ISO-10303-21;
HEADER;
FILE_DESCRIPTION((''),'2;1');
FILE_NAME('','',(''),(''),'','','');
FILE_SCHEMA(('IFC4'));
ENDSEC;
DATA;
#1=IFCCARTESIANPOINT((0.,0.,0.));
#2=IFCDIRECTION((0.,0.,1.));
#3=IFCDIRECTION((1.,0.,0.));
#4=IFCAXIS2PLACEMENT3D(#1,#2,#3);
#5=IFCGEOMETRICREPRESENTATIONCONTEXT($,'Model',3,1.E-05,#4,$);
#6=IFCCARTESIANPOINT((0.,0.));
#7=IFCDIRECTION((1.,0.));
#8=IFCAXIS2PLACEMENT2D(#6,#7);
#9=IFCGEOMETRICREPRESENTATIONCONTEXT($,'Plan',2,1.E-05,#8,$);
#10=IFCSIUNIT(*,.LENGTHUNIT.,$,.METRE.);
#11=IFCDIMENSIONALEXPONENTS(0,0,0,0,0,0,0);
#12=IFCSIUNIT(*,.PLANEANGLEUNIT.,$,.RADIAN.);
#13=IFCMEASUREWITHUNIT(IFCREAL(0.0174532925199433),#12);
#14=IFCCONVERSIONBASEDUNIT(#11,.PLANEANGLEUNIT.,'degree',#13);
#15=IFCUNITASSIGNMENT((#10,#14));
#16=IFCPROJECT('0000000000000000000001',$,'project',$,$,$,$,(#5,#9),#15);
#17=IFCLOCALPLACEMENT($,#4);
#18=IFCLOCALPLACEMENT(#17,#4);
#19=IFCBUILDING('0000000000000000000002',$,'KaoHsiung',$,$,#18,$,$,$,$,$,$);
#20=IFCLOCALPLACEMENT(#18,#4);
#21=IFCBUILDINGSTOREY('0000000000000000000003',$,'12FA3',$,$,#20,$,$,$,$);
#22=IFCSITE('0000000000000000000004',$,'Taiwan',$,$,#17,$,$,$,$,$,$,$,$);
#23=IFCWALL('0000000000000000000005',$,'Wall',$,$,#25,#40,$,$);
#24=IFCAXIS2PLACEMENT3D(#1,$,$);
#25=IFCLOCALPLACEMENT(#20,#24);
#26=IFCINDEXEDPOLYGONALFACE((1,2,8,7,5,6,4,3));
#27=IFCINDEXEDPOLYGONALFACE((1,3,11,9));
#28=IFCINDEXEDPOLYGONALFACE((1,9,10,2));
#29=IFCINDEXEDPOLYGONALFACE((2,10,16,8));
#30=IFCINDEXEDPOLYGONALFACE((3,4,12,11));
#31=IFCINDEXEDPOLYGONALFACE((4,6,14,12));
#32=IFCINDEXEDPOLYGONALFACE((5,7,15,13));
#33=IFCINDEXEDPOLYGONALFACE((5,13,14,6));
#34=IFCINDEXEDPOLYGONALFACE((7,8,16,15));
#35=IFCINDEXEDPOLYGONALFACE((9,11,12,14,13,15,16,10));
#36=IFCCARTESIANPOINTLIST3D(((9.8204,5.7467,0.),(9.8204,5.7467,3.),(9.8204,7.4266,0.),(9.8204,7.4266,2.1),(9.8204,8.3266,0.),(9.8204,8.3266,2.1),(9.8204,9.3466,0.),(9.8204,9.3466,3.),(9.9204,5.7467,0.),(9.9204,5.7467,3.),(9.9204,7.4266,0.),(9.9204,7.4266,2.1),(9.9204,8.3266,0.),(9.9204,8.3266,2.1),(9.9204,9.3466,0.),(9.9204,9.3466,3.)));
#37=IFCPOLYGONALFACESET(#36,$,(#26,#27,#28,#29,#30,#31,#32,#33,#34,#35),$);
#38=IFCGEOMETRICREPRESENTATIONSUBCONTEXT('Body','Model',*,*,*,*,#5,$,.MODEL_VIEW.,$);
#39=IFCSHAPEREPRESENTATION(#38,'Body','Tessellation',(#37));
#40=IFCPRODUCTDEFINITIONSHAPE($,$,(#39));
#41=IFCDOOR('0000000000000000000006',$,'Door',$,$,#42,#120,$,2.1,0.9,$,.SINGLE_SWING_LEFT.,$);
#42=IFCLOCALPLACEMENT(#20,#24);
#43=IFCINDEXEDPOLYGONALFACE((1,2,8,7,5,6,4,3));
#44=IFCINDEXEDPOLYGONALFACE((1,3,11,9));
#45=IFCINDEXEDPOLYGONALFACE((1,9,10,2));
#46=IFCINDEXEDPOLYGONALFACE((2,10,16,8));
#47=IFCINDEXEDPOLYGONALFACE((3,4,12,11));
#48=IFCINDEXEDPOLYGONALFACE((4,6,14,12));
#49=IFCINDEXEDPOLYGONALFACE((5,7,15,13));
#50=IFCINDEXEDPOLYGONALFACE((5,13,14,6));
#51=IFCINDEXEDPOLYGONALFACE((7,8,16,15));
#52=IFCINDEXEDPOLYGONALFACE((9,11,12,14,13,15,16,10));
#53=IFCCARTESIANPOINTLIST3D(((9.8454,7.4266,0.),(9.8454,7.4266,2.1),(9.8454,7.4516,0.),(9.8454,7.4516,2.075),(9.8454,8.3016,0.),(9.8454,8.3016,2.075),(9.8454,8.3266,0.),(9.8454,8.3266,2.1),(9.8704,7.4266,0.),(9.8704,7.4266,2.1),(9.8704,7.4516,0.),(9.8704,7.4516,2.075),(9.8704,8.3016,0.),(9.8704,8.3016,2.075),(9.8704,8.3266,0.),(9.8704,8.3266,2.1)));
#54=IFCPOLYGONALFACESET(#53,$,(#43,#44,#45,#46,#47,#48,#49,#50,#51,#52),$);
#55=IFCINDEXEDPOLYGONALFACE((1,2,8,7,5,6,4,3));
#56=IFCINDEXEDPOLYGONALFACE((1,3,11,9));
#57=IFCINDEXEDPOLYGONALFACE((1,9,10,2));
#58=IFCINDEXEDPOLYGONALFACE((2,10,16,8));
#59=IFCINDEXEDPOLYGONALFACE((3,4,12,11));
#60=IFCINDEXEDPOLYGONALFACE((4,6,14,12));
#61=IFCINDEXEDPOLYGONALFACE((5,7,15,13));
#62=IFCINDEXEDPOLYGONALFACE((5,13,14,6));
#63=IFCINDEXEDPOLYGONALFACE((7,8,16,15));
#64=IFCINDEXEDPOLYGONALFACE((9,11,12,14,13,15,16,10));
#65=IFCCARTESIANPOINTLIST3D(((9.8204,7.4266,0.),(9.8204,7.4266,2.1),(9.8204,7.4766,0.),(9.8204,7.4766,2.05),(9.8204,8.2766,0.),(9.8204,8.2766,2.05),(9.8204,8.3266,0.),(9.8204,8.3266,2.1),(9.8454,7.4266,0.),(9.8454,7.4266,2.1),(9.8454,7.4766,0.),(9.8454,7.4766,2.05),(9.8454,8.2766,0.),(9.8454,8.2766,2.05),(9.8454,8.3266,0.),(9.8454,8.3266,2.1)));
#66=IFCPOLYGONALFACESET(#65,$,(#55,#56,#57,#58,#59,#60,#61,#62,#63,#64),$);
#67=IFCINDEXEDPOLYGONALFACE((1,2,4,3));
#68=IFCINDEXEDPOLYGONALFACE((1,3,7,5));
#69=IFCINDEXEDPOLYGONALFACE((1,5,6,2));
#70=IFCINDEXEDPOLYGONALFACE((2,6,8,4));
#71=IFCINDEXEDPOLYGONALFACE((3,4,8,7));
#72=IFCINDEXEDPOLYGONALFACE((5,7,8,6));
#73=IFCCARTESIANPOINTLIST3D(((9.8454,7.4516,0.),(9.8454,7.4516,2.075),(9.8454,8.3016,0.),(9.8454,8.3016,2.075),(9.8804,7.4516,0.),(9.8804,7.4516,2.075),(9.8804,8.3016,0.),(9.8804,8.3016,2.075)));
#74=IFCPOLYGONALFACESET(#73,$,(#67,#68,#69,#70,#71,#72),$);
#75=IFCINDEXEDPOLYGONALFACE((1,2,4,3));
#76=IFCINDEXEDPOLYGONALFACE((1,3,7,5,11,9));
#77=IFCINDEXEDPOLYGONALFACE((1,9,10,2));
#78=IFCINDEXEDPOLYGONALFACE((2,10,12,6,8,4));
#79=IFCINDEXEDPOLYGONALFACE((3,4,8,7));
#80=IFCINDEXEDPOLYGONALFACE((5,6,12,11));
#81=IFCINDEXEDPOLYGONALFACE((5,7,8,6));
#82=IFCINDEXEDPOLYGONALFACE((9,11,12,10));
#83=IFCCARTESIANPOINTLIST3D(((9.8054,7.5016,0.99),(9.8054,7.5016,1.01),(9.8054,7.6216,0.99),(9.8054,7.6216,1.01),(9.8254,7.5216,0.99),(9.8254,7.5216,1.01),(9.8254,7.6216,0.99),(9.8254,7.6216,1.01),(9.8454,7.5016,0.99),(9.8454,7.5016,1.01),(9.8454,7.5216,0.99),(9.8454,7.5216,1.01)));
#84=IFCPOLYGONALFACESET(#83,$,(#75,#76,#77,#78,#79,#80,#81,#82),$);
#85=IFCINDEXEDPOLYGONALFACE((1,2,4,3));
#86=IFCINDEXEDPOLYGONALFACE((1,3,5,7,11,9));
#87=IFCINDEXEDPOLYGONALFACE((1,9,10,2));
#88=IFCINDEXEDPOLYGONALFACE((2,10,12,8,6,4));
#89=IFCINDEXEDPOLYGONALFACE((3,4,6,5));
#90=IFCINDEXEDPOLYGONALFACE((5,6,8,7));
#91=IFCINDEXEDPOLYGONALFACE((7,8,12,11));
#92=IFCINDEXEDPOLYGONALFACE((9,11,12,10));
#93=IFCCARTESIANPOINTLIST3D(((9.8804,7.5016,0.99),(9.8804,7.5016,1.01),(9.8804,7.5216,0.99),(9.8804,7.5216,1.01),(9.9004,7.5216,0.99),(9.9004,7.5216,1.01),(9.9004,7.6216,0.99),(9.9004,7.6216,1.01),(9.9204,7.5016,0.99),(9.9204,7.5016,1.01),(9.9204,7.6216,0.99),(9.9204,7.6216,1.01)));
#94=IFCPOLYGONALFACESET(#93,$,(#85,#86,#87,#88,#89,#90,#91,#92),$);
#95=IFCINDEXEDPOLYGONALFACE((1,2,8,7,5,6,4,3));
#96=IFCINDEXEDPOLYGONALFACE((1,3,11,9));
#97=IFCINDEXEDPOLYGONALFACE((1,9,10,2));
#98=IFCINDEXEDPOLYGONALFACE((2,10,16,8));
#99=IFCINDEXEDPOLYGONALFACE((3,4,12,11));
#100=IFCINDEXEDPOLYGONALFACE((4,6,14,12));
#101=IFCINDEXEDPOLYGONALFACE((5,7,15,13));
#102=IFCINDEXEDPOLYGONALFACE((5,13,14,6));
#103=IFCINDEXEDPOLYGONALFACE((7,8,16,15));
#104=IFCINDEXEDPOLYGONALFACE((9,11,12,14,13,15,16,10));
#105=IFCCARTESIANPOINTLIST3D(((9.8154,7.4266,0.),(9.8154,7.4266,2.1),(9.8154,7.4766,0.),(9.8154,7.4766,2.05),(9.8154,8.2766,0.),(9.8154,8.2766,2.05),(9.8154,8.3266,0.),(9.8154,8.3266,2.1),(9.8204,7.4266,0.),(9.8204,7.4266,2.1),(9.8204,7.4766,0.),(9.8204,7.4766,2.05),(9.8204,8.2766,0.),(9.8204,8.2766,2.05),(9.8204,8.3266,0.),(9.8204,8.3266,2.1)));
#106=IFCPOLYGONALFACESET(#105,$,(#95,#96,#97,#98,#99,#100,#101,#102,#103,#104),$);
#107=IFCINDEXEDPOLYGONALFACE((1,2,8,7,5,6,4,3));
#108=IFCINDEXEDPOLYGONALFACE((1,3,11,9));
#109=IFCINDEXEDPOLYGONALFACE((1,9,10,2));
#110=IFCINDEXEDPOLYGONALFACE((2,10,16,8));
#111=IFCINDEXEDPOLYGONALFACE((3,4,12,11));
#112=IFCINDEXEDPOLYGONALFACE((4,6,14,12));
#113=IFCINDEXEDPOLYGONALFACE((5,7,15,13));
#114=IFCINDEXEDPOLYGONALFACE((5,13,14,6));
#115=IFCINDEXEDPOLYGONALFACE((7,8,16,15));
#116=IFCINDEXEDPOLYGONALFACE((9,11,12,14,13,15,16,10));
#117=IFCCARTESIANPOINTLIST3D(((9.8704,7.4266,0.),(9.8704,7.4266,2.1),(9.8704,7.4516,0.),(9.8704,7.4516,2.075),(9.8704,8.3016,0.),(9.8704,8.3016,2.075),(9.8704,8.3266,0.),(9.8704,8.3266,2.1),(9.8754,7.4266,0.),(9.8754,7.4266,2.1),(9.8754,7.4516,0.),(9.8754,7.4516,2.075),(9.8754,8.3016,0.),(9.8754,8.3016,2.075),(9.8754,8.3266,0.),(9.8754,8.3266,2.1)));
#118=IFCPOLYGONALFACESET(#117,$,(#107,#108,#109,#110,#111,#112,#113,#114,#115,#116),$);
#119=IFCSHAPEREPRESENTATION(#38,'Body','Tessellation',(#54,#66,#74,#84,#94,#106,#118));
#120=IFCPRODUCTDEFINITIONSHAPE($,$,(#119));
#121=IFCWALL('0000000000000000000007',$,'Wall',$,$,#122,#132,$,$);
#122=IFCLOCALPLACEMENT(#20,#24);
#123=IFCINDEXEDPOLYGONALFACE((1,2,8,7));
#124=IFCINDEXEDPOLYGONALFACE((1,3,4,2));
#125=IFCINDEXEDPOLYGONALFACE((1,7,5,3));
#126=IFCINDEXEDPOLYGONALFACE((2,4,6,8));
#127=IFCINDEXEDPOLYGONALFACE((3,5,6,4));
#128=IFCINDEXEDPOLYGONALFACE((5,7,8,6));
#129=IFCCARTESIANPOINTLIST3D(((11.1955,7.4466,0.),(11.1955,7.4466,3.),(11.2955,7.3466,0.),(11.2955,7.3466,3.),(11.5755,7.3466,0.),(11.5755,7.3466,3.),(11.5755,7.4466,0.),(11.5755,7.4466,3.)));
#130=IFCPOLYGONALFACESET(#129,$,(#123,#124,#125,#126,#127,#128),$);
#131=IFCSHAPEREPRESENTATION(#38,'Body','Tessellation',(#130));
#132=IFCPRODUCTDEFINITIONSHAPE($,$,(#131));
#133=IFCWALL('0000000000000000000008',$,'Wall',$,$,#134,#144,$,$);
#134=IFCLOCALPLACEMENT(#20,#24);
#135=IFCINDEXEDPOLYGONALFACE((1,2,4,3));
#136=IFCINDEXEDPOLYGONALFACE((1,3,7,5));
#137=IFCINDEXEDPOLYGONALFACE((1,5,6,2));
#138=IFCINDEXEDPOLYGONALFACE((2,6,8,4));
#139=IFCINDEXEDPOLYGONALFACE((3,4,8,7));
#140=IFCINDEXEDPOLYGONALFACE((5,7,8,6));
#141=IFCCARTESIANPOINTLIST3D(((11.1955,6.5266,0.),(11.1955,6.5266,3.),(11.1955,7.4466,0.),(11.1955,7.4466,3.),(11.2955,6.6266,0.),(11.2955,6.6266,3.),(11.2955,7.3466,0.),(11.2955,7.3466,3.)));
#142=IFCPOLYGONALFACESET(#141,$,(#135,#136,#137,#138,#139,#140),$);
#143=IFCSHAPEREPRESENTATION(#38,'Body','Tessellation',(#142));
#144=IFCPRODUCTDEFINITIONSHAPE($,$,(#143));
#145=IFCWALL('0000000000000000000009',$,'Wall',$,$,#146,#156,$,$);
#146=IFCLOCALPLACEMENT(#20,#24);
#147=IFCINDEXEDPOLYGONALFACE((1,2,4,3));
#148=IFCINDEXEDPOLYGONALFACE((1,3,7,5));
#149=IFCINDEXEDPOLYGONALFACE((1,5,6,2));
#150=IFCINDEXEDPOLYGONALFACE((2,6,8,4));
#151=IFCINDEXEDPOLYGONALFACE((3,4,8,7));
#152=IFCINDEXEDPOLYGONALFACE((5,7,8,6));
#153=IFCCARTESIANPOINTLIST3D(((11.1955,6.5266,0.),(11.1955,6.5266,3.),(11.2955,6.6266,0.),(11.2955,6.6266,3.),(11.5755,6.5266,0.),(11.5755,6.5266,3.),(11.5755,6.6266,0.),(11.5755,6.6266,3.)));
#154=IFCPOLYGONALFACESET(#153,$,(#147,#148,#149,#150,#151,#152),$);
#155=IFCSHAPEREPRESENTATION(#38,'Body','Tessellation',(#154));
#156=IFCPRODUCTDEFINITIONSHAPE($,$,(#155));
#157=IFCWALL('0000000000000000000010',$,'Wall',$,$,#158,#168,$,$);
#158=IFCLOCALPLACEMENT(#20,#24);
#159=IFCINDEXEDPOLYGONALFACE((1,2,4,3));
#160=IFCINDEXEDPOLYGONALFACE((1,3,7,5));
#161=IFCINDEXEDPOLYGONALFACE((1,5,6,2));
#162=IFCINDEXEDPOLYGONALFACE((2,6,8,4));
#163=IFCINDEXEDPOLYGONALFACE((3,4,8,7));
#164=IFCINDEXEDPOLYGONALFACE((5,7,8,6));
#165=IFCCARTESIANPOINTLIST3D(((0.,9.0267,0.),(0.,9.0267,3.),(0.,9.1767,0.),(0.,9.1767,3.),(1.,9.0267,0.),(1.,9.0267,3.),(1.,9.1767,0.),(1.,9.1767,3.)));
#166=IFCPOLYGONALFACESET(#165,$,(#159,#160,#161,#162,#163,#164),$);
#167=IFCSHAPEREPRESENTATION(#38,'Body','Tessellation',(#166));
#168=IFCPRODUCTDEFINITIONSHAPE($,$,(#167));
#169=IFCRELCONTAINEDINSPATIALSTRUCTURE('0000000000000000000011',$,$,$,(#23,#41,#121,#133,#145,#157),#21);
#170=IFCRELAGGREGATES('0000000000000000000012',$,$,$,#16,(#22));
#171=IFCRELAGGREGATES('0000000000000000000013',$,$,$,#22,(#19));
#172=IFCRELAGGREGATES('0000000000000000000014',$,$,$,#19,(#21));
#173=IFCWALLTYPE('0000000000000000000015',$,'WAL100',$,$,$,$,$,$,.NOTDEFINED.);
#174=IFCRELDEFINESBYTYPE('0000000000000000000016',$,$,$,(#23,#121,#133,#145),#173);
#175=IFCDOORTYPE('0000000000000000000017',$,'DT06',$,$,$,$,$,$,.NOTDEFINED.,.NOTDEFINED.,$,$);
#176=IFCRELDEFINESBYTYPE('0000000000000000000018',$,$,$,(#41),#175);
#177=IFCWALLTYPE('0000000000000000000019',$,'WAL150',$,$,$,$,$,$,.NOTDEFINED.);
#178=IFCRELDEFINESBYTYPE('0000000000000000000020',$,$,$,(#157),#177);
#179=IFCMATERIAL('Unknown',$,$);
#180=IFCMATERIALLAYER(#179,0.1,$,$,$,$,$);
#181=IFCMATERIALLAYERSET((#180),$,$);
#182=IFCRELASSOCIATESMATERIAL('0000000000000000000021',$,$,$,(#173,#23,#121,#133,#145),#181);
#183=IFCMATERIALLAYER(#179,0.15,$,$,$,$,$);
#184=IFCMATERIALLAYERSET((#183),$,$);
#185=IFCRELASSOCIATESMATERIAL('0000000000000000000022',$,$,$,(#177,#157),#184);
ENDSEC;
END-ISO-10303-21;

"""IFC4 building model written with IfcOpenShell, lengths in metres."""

from ifc_helpers import new_model, entity, si_unit, converted_unit, frame, origin_with_axes, origin_2d_with_axis, place, context, subcontext, project, spatial, line, indexed_curve, outline, extrude, shape, source, transform, mapped, material, layer, layer_set, layer_usage, type_object, type_shapes, element, fill, save


model = new_model("IFC4")

# Units and contexts
model_context = context("Model", 3, precision=1e-05, world=origin_with_axes())
plan_context = context("Plan", 2, precision=1e-05, world=origin_2d_with_axis())
body_context_1 = subcontext(model_context, "Body", "Model", "MODEL_VIEW")
body_context_2 = subcontext(plan_context, "Body", "Plan", "PLAN_VIEW")
ifc_project = project(units=[si_unit("LENGTHUNIT", "METRE"), converted_unit("PLANEANGLEUNIT", "degree", entity("IfcReal", 0.0174532925199433), si_unit("PLANEANGLEUNIT", "RADIAN"), dimensions=[0, 0, 0, 0, 0, 0, 0])], contexts=[model_context, plan_context])

# Site, building, storey
site_placement = place(None, origin_with_axes())
site = spatial("IfcSite", under=ifc_project, at=site_placement, Name="Taiwan")
building_placement = place(site_placement, origin_with_axes())
building = spatial("IfcBuilding", under=site, at=building_placement, Name="KaoHsiung")
storey_placement = place(building_placement, origin_with_axes())
storey = spatial("IfcBuildingStorey", under=building, at=storey_placement, Name="12FA3")

# Shared definitions
ifc_material = material(Name="Unknown")

# Shared definitions
ifc_layer_1 = layer(ifc_material, 0.1)
ifc_layer_set_1 = layer_set([ifc_layer_1])
wall_type_1 = type_object("IfcWallType", Name="WAL100", PredefinedType="NOTDEFINED", material=ifc_layer_set_1)

# Wall, opening, door
ifc_layer_usage_1 = layer_usage(ifc_layer_set_1, "AXIS2", "POSITIVE", 0.0)
wall_1_placement = place(storey_placement, frame((9.8204, 9.3466, 0.0), z_axis=(0.0, 0.0, 1.0), x_axis=(0.0, -1.0, 0.0)))
wall_1 = element("IfcWall", 1, at=wall_1_placement, inside=storey, type_object=wall_type_1, material=ifc_layer_usage_1, Name="Wall", context=body_context_1, shape_type="SweptSolid", body=[
    extrude(outline(indexed_curve([(0.0, 0.0), (0.0, 0.1), (3.5999, 0.1), (3.5999, 0.0)], segments=[line(1, 2, 3, 4, 1)])), origin_with_axes(), (0.0, 0.0, 1.0), 3.0),
])
shared_shape_1 = source(origin_with_axes(), body_context_1, "Body", "SweptSolid", [
    extrude(outline(indexed_curve([(0.0, 0.0), (0.9, 0.0), (0.9, 2.1), (0.0, 2.1)], segments=[line(1, 2, 3, 4, 1)])), frame((0.0, -0.6, 0.0), z_axis=(0.0, -1.0, 0.0), x_axis=(1.0, 0.0, 0.0)), (0.0, 0.0, -1.0), 1.2),
])
opening_1_placement = place(wall_1_placement, frame((1.0199, 0.0, 0.0), z_axis=(0.0, 0.0, 1.0), x_axis=(1.0, 0.0, 0.0)))
opening_1 = element("IfcOpeningElement", 2, at=opening_1_placement, cuts=wall_1, PredefinedType="OPENING", context=body_context_1, shape_type="MappedRepresentation", body=[
    mapped(shared_shape_1, transform((0.0, 0.0, 0.0), x_axis=(1.0, 0.0, 0.0), y_axis=(0.0, 1.0, 0.0), z_axis=(0.0, 0.0, 1.0), scale=1.0)),
])
door_type_1 = type_object("IfcDoorType", Name="DT06", OperationType="NOTDEFINED", PredefinedType="NOTDEFINED")
shared_shape_2 = source(origin_with_axes(), body_context_1, "Body", "SweptSolid", [
    extrude(outline(indexed_curve([(0.0, 0.0), (0.0, 2.1), (0.9, 2.1), (0.9, 0.0), (0.875, 0.0), (0.875, 2.075), (0.025, 2.075), (0.025, 0.0)], segments=[line(1, 2, 3, 4, 5, 6, 7, 8, 1)])), frame((0.0, 0.025, 0.0), z_axis=(0.0, -1.0, 0.0), x_axis=(1.0, 0.0, 0.0)), (0.0, 0.0, -1.0), 0.025),
    extrude(outline(indexed_curve([(0.0, 0.0), (0.0, 2.1), (0.9, 2.1), (0.9, 0.0), (0.85, 0.0), (0.85, 2.05), (0.05, 2.05), (0.05, 0.0)], segments=[line(1, 2, 3, 4, 5, 6, 7, 8, 1)])), frame((0.0, 0.0, 0.0), z_axis=(0.0, -1.0, 0.0), x_axis=(1.0, 0.0, 0.0)), (0.0, 0.0, -1.0), 0.025),
    extrude(outline(indexed_curve([(0.0, 0.0), (0.85, 0.0), (0.85, 0.035), (0.0, 0.035)], segments=[line(1, 2, 3, 4, 1)])), frame((0.025, 0.025, 0.0), z_axis=(0.0, 0.0, 1.0), x_axis=(1.0, 0.0, 0.0)), (0.0, 0.0, 1.0), 2.075),
    extrude(outline(indexed_curve([(0.0, 0.0), (0.0, -0.04), (-0.12, -0.04), (-0.12, -0.02), (-0.02, -0.02), (-0.02, 0.0)], segments=[line(1, 2, 3, 4, 5, 6, 1)])), frame((0.825, 0.025, 0.99), z_axis=(0.0, 0.0, 1.0), x_axis=(1.0, 0.0, 0.0)), (0.0, 0.0, 1.0), 0.02),
    extrude(outline(indexed_curve([(0.0, 0.0), (0.0, 0.04), (-0.12, 0.04), (-0.12, 0.02), (-0.02, 0.02), (-0.02, 0.0)], segments=[line(1, 2, 3, 4, 5, 6, 1)])), frame((0.825, 0.06, 0.99), z_axis=(0.0, 0.0, 1.0), x_axis=(1.0, 0.0, 0.0)), (0.0, 0.0, 1.0), 0.02),
    extrude(outline(indexed_curve([(0.0, 0.0), (0.0, 2.1), (0.9, 2.1), (0.9, 0.0), (0.85, 0.0), (0.85, 2.05), (0.05, 2.05), (0.05, 0.0)], segments=[line(1, 2, 3, 4, 5, 6, 7, 8, 1)])), frame((0.0, -0.005, 0.0), z_axis=(0.0, -1.0, 0.0), x_axis=(1.0, 0.0, 0.0)), (0.0, 0.0, -1.0), 0.005),
    extrude(outline(indexed_curve([(0.0, 0.0), (0.0, 2.1), (0.9, 2.1), (0.9, 0.0), (0.875, 0.0), (0.875, 2.075), (0.025, 2.075), (0.025, 0.0)], segments=[line(1, 2, 3, 4, 5, 6, 7, 8, 1)])), frame((0.0, 0.05, 0.0), z_axis=(0.0, -1.0, 0.0), x_axis=(1.0, 0.0, 0.0)), (0.0, 0.0, -1.0), 0.005),
])
shared_shape_3 = source(origin_with_axes(), body_context_2, "Body", "Curve2D", [
    entity("IfcIndexedPolyCurve", entity("IfcCartesianPointList2D", [[0.0, 0.0], [0.0, 0.05], [0.025, 0.05], [0.025, 0.025], [0.05, 0.025], [0.05, 0.0]]), [entity("IfcLineIndex", [1, 2, 3, 4, 5, 6, 1])]),
    entity("IfcIndexedPolyCurve", entity("IfcCartesianPointList2D", [[0.9, 0.0], [0.9, 0.05], [0.875, 0.05], [0.875, 0.025], [0.85, 0.025], [0.85, 0.0]]), [entity("IfcLineIndex", [1, 2, 3, 4, 5, 6, 1])]),
    entity("IfcTrimmedCurve", entity("IfcEllipse", entity("IfcAxis2Placement2D", entity("IfcCartesianPoint", [0.06, 0.05]), entity("IfcDirection", [1.0, 0.0])), 0.815, 0.85), [entity("IfcCartesianPoint", [0.875, 0.05])], [entity("IfcCartesianPoint", [0.06, 0.9])], True, "CARTESIAN"),
    entity("IfcIndexedPolyCurve", entity("IfcCartesianPointList2D", [[0.025, 0.05], [0.06, 0.05], [0.06, 0.9], [0.025, 0.9]]), [entity("IfcLineIndex", [1, 2, 3, 4, 1])]),
])
type_shapes(door_type_1, [shared_shape_2, shared_shape_3])
door_1_placement = place(opening_1_placement, origin_with_axes())
door_1 = element("IfcDoor", 3, at=door_1_placement, inside=storey, type_object=door_type_1, Name="Door", OperationType="SINGLE_SWING_LEFT", OverallHeight=2.1, OverallWidth=0.9, shapes=[
    shape(body_context_1, "Body", "MappedRepresentation", [mapped(shared_shape_2, transform((0.0, 0.0, 0.0), x_axis=(1.0, 0.0, 0.0), y_axis=(0.0, 1.0, 0.0), z_axis=(0.0, 0.0, 1.0), scale=1.0))]),
    shape(body_context_2, "Body", "MappedRepresentation", [mapped(shared_shape_3, transform((0.0, 0.0, 0.0), x_axis=(1.0, 0.0, 0.0), y_axis=(0.0, 1.0, 0.0), z_axis=(0.0, 0.0, 1.0), scale=1.0))]),
])
fill(opening_1, door_1)

# Walls
ifc_layer_usage_2 = layer_usage(ifc_layer_set_1, "AXIS2", "POSITIVE", 0.0)
wall_2_placement = place(storey_placement, frame((11.5755, 7.4466, 0.0), z_axis=(0.0, 0.0, 1.0), x_axis=(-1.0, 0.0, 0.0)))
element("IfcWall", 4, at=wall_2_placement, inside=storey, type_object=wall_type_1, material=ifc_layer_usage_2, Name="Wall", context=body_context_1, shape_type="SweptSolid", body=[
    extrude(outline(indexed_curve([(0.0, 0.0), (0.0, 0.1), (0.28, 0.1), (0.38, 0.0)], segments=[line(1, 2, 3, 4, 1)])), origin_with_axes(), (0.0, 0.0, 1.0), 3.0),
])
ifc_layer_usage_3 = layer_usage(ifc_layer_set_1, "AXIS2", "POSITIVE", 0.0)
wall_3_placement = place(storey_placement, frame((11.1955, 7.4466, 0.0), z_axis=(0.0, 0.0, 1.0), x_axis=(0.0, -1.0, 0.0)))
element("IfcWall", 5, at=wall_3_placement, inside=storey, type_object=wall_type_1, material=ifc_layer_usage_3, Name="Wall", context=body_context_1, shape_type="SweptSolid", body=[
    extrude(outline(indexed_curve([(0.0, 0.0), (0.1, 0.1), (0.82, 0.1), (0.92, 0.0)], segments=[line(1, 2, 3, 4, 1)])), origin_with_axes(), (0.0, 0.0, 1.0), 3.0),
])
ifc_layer_usage_4 = layer_usage(ifc_layer_set_1, "AXIS2", "POSITIVE", 0.0)
wall_4_placement = place(storey_placement, frame((11.1955, 6.5266, 0.0), z_axis=(0.0, 0.0, 1.0), x_axis=(1.0, 0.0, 0.0)))
element("IfcWall", 6, at=wall_4_placement, inside=storey, type_object=wall_type_1, material=ifc_layer_usage_4, Name="Wall", context=body_context_1, shape_type="SweptSolid", body=[
    extrude(outline(indexed_curve([(0.0, 0.0), (0.1, 0.1), (0.38, 0.1), (0.38, 0.0)], segments=[line(1, 2, 3, 4, 1)])), origin_with_axes(), (0.0, 0.0, 1.0), 3.0),
])
ifc_layer_2 = layer(ifc_material, 0.15)
ifc_layer_set_2 = layer_set([ifc_layer_2])
ifc_layer_usage_5 = layer_usage(ifc_layer_set_2, "AXIS2", "POSITIVE", 0.0)
wall_type_2 = type_object("IfcWallType", Name="WAL150", PredefinedType="NOTDEFINED", material=ifc_layer_set_2)
wall_5_placement = place(storey_placement, frame((0.0, 9.0267, 0.0), z_axis=(0.0, 0.0, 1.0), x_axis=(1.0, 0.0, 0.0)))
element("IfcWall", 7, at=wall_5_placement, inside=storey, type_object=wall_type_2, material=ifc_layer_usage_5, Name="Wall", context=body_context_1, shape_type="SweptSolid", body=[
    extrude(outline(indexed_curve([(0.0, 0.0), (0.0, 0.15), (1.0, 0.15), (1.0, 0.0)], segments=[line(1, 2, 3, 4, 1)])), origin_with_axes(), (0.0, 0.0, 1.0), 3.0),
])

save(model, "model.ifc")
